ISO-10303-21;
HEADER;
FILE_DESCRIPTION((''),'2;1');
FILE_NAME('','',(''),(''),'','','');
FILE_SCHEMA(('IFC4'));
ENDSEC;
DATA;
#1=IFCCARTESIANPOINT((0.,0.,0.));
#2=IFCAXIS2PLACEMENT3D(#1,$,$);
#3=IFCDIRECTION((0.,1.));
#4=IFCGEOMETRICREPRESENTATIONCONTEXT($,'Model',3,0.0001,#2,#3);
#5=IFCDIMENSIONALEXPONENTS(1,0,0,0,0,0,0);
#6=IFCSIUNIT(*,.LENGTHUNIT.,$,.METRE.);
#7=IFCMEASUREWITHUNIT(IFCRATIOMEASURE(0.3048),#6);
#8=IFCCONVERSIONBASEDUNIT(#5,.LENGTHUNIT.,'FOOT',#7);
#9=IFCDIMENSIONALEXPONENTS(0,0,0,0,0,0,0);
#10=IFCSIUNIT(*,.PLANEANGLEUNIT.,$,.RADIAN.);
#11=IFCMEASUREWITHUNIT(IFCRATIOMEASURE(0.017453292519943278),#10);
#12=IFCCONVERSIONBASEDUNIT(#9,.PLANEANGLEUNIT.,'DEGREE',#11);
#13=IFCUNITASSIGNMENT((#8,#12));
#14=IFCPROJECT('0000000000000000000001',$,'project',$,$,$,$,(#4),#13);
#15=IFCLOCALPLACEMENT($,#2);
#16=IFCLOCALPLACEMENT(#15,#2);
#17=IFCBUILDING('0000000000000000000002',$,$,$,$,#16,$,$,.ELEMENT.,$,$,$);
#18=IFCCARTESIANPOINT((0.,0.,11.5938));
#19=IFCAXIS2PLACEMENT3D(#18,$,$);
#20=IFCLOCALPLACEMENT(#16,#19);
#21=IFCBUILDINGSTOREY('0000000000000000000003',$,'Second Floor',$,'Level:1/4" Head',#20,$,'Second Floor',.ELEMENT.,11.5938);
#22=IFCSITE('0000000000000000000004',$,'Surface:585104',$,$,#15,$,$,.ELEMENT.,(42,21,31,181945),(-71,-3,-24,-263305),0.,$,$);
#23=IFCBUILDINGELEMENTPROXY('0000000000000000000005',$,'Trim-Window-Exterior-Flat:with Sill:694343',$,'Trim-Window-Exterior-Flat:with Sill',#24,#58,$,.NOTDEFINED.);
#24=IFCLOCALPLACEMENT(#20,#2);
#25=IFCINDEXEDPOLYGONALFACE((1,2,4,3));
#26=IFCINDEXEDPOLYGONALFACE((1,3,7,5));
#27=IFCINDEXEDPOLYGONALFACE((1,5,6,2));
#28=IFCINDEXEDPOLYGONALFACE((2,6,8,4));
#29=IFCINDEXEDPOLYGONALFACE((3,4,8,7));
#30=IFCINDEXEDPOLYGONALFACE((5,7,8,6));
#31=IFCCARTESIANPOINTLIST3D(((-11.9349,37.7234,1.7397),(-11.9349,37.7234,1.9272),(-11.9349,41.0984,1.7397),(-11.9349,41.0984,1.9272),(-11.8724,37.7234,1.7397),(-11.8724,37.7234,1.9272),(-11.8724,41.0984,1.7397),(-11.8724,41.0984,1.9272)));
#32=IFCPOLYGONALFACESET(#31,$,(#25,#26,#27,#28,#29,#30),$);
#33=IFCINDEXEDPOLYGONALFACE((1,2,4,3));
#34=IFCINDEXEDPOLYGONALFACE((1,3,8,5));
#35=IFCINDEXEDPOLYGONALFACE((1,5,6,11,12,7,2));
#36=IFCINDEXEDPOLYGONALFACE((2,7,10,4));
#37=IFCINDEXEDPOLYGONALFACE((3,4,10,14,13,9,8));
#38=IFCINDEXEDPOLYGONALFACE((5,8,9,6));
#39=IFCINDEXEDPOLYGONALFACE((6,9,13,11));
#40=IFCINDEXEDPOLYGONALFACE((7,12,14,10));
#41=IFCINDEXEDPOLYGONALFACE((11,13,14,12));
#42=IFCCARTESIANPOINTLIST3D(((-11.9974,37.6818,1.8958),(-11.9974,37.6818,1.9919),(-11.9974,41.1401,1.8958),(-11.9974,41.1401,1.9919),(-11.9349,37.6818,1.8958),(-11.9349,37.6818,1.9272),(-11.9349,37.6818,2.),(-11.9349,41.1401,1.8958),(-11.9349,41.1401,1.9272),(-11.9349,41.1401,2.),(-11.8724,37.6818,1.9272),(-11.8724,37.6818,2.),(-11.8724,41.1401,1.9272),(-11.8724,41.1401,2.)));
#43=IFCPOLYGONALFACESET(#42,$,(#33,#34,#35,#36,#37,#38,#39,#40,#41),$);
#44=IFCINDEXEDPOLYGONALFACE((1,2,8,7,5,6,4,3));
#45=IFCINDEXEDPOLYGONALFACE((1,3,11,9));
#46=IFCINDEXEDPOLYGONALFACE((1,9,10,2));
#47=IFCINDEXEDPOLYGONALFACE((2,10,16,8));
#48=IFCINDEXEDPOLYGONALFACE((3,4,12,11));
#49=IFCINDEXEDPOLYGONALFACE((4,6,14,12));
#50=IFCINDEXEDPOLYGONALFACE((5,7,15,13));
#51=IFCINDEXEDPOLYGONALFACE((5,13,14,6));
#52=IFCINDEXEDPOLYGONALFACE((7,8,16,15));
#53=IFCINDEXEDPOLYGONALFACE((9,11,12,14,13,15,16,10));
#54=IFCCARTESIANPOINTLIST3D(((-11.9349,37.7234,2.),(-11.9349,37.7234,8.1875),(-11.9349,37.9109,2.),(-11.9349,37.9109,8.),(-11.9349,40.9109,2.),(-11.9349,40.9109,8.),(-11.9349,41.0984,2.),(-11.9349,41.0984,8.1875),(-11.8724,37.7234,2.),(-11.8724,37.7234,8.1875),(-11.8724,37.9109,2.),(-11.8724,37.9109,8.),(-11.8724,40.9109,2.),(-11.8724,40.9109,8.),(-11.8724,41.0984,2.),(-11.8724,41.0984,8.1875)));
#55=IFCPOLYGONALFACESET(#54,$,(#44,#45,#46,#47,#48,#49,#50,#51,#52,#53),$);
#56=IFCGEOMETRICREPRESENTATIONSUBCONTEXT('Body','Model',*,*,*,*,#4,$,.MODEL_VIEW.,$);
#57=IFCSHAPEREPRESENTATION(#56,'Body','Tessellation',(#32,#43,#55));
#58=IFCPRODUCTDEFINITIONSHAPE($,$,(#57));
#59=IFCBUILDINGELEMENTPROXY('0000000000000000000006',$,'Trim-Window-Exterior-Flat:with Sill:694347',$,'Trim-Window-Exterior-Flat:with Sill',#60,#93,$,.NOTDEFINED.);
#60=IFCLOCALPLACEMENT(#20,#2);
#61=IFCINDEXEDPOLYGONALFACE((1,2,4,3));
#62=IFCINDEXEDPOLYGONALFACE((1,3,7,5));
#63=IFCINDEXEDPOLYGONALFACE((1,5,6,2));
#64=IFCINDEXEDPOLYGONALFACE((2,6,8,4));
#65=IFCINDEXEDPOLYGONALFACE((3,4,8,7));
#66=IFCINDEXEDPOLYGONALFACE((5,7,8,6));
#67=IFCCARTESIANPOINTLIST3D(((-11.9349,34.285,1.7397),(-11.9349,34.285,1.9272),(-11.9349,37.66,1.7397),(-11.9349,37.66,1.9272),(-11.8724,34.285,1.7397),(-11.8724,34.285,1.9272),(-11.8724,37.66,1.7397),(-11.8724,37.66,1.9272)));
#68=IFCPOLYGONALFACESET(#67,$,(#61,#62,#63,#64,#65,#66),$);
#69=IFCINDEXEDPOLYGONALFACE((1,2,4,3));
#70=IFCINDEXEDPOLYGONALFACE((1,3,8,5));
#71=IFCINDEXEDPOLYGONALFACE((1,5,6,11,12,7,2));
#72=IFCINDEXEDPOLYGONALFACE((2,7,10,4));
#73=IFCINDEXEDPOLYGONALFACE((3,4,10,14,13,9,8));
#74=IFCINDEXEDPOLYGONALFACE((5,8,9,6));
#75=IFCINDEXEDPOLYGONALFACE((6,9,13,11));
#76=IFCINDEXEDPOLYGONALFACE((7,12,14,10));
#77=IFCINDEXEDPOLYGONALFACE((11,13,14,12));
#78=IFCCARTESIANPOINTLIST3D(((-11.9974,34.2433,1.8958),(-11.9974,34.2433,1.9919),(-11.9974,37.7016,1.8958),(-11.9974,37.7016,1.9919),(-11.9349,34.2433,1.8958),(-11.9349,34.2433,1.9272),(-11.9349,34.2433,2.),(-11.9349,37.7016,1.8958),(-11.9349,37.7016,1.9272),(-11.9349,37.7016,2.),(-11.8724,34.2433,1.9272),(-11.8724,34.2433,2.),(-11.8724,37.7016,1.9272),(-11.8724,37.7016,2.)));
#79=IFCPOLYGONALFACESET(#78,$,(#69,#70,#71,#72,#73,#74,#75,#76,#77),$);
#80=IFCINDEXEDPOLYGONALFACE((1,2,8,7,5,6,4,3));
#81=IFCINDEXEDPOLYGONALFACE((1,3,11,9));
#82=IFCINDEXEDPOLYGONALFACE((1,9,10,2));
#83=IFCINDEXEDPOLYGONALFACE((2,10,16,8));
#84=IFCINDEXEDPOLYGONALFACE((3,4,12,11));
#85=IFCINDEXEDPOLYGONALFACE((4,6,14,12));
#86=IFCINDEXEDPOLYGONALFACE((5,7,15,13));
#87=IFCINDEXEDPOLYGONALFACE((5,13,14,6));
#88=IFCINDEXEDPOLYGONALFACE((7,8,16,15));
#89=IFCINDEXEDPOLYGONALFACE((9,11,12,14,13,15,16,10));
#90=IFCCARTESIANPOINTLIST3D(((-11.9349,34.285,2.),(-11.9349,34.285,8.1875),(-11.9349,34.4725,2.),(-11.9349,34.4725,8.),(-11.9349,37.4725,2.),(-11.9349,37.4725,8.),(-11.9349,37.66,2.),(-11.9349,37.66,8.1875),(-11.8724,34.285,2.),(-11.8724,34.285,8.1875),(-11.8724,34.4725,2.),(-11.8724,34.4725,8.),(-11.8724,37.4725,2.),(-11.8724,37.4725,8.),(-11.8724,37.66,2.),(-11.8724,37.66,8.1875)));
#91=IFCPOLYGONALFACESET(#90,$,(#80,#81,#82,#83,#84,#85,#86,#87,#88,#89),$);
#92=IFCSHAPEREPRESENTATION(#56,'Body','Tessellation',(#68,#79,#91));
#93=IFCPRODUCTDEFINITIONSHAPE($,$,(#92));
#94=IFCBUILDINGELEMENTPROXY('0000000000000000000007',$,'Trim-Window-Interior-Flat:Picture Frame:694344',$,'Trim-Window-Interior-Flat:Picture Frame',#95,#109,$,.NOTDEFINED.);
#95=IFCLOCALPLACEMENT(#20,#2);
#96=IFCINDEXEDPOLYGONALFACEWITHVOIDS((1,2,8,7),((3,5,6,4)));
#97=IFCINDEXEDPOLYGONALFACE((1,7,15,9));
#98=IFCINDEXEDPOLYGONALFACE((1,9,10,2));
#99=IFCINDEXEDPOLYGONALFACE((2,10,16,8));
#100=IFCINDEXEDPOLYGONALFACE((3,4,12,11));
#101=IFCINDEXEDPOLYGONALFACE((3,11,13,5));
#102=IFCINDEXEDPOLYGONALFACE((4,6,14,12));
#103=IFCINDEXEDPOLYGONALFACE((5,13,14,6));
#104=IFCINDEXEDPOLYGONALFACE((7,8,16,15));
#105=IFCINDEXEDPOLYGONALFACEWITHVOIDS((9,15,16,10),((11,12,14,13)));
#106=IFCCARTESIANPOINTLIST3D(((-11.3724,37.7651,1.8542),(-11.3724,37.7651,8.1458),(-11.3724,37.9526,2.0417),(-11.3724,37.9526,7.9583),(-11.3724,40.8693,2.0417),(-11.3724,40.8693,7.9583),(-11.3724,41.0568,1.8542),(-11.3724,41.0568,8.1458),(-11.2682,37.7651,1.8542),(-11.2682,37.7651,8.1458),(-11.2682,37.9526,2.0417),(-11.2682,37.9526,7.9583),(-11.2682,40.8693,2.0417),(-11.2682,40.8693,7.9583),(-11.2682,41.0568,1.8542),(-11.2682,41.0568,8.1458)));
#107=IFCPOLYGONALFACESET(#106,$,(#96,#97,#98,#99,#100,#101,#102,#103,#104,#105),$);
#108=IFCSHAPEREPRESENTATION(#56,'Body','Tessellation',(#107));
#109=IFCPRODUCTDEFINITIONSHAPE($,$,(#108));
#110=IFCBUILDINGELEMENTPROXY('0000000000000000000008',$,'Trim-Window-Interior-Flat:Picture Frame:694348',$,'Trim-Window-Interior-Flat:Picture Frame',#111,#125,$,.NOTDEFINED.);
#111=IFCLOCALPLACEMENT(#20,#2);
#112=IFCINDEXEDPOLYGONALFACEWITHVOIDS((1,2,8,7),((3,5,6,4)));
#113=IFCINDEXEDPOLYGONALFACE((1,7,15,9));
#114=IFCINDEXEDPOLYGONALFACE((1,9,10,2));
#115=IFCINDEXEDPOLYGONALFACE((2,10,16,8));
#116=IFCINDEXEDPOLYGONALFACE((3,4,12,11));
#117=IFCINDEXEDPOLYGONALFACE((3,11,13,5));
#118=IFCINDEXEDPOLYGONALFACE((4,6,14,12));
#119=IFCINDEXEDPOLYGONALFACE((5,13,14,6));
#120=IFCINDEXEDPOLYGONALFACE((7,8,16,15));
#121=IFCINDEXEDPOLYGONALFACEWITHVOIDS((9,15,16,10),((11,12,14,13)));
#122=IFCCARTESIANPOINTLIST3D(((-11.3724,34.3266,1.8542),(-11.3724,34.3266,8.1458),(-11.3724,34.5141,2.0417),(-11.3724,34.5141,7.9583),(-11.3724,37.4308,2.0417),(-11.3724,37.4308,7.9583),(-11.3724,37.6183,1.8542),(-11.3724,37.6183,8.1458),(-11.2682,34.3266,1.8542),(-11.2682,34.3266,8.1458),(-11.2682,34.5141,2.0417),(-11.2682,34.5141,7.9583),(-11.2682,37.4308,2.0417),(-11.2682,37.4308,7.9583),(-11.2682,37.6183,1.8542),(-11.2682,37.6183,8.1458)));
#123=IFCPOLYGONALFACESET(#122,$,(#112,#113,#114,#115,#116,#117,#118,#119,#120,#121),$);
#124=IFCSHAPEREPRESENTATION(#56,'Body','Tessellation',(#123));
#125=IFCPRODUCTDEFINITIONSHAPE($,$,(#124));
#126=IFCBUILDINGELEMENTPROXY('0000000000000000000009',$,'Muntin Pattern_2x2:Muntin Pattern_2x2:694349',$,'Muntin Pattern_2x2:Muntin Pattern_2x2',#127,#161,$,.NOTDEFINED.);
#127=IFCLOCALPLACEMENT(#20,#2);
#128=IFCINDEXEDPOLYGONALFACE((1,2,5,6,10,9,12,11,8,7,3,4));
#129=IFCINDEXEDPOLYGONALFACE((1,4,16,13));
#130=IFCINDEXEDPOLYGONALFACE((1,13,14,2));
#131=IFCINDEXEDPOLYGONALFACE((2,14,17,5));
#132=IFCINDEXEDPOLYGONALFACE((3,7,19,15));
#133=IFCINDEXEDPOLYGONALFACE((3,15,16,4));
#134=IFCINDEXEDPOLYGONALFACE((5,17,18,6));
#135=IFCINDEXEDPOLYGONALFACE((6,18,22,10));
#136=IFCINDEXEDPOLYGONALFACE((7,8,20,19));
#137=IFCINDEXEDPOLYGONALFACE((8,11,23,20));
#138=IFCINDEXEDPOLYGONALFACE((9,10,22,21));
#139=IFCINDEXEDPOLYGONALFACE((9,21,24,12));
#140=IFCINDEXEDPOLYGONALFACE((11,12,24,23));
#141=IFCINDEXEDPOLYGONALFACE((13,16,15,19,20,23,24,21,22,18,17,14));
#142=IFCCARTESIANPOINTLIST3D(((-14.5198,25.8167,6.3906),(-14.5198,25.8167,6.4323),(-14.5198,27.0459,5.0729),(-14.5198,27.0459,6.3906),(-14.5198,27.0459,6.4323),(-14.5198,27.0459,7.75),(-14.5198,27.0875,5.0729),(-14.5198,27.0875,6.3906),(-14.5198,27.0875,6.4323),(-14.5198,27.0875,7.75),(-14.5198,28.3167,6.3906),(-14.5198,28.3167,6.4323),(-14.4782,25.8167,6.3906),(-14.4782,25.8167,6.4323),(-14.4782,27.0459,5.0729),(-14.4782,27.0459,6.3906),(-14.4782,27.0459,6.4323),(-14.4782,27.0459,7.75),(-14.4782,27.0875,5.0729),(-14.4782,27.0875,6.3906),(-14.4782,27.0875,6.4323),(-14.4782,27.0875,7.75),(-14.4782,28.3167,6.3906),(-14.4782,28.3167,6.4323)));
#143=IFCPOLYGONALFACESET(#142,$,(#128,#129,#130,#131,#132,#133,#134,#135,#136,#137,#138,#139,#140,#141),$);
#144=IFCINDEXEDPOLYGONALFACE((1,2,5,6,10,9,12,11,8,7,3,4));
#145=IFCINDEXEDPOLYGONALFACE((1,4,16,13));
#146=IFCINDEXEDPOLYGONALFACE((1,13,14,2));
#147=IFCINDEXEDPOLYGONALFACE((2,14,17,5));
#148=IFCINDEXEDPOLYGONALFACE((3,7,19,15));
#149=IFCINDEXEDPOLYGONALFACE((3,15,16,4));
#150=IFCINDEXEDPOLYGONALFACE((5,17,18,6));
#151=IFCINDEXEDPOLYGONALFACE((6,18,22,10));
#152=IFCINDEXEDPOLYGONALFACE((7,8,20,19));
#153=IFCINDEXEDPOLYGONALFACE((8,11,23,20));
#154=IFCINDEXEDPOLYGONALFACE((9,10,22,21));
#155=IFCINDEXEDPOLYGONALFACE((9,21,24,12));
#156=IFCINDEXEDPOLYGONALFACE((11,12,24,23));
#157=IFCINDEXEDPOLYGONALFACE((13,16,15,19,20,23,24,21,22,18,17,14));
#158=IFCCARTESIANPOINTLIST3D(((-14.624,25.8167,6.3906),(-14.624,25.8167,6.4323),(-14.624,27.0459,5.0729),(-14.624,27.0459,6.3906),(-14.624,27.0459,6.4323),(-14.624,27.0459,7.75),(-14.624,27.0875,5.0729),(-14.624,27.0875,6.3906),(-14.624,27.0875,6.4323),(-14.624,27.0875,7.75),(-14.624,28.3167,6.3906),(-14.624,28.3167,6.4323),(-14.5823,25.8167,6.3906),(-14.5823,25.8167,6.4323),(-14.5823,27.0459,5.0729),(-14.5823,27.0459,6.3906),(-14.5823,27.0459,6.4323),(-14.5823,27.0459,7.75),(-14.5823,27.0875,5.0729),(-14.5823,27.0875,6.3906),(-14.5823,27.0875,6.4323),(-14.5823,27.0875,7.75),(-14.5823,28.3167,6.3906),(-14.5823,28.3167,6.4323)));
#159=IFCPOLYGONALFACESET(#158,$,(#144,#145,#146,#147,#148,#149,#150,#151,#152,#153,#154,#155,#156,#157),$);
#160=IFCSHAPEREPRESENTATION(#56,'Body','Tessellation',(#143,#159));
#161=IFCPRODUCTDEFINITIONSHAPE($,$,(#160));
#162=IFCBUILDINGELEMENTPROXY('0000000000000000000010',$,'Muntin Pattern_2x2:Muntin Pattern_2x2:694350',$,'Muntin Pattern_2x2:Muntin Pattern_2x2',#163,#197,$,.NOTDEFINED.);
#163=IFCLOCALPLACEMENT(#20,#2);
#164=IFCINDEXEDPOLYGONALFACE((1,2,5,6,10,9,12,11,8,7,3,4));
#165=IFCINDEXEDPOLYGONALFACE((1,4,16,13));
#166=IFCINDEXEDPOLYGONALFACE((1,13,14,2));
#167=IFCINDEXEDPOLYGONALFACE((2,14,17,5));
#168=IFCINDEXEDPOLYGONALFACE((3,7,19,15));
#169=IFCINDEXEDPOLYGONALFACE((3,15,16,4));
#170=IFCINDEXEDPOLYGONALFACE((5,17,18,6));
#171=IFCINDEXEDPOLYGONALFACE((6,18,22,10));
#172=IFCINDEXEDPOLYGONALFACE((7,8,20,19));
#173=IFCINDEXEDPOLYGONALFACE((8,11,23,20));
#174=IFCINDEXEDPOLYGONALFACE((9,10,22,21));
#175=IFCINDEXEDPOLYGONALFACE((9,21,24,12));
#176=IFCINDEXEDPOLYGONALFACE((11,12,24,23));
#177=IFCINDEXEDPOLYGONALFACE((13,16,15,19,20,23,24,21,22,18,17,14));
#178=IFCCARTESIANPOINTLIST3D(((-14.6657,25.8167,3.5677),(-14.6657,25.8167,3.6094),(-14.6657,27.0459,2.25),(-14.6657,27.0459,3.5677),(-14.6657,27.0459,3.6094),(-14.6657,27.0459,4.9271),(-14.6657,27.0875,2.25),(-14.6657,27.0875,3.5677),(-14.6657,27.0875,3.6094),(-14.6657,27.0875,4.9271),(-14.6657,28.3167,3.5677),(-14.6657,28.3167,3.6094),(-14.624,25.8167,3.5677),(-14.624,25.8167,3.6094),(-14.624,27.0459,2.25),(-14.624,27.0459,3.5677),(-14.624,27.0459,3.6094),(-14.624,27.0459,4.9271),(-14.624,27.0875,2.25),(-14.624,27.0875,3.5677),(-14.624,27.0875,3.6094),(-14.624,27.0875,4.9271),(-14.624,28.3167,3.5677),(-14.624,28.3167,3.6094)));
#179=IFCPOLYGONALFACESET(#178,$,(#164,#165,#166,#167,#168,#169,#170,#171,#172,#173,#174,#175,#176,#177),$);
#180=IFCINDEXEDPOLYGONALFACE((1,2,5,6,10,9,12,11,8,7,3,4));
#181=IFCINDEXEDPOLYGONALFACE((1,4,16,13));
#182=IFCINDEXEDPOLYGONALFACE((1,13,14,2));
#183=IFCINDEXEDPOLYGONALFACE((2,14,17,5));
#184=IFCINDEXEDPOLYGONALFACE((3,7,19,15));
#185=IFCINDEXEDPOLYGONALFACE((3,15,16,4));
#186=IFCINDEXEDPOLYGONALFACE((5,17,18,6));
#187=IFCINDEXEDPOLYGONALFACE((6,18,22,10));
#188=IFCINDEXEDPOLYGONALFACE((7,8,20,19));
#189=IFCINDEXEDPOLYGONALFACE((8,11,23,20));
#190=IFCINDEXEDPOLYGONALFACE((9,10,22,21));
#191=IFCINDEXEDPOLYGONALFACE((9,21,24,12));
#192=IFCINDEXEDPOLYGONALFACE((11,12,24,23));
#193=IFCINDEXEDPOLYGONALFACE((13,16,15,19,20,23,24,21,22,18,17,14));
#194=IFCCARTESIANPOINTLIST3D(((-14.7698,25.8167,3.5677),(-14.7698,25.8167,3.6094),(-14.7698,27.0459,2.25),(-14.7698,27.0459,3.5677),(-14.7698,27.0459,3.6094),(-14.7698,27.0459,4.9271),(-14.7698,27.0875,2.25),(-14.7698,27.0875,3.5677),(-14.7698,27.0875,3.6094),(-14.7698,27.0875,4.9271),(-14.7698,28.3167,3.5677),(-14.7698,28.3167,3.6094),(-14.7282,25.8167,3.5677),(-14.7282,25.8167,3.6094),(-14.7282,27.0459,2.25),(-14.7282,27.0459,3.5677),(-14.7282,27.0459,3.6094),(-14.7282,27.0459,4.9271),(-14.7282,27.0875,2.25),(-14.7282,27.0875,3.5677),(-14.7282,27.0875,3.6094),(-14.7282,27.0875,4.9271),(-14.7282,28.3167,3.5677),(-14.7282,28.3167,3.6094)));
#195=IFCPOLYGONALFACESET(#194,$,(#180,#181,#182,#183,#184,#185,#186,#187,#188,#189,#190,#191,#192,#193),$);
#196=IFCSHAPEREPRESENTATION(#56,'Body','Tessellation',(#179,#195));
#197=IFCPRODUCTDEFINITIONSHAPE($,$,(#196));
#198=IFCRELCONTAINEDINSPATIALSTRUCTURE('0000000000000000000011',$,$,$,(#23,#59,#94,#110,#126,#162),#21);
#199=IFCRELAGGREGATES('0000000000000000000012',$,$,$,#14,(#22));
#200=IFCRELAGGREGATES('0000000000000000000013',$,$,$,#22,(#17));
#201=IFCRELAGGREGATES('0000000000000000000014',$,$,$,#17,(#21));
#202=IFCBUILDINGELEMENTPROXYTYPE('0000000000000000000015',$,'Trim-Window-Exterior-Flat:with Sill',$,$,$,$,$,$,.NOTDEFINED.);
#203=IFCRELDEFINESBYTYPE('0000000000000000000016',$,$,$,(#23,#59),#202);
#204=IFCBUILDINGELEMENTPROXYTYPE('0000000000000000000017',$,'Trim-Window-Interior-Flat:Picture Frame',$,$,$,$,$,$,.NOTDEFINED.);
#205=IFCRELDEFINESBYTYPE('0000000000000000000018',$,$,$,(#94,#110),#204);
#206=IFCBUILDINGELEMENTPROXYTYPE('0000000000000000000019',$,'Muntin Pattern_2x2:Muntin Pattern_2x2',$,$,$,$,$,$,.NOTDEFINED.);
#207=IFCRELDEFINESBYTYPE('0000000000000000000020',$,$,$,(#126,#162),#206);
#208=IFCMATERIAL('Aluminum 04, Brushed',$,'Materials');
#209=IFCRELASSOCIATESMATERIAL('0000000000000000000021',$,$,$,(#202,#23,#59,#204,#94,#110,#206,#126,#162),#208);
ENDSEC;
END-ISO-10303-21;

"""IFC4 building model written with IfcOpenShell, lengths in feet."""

from ifc_helpers import new_model, entity, si_unit, converted_unit, direction, frame, origin, place, context, subcontext, project, spatial, indexed_curve, outline, extrude, source, transform, mapped, material, type_object, type_shapes, element, save


model = new_model("IFC4")

# Units and contexts
model_context = context("Model", 3, precision=0.0001, world=origin(), true_north=direction((0.0, 1.0)))
body_context = subcontext(model_context, "Body", "Model", "MODEL_VIEW")
ifc_project = project(units=[converted_unit("LENGTHUNIT", "FOOT", entity("IfcRatioMeasure", 0.3048), si_unit("LENGTHUNIT", "METRE"), dimensions=[1, 0, 0, 0, 0, 0, 0]), converted_unit("PLANEANGLEUNIT", "DEGREE", entity("IfcRatioMeasure", 0.017453292519943278), si_unit("PLANEANGLEUNIT", "RADIAN"), dimensions=[0, 0, 0, 0, 0, 0, 0])], contexts=[model_context])

# Site, building, storey
site_placement = place(None, origin())
site = spatial("IfcSite", under=ifc_project, at=site_placement, Name="Surface:585104", CompositionType="ELEMENT", RefLatitude=(42, 21, 31, 181945), RefLongitude=(-71, -3, -24, -263305), RefElevation=0.0)
building_placement = place(site_placement, origin())
building = spatial("IfcBuilding", under=site, at=building_placement, CompositionType="ELEMENT")
storey_placement = place(building_placement, frame((0.0, 0.0, 11.5938)))
storey = spatial("IfcBuildingStorey", under=building, at=storey_placement, Name="Second Floor", ObjectType="Level:1/4\" Head", LongName="Second Floor", CompositionType="ELEMENT", Elevation=11.5938)

# Building element proxies
ifc_material_1 = material(Name="Aluminum 04, Brushed", Category="Materials")
building_element_proxy_type_1 = type_object("IfcBuildingElementProxyType", Name="Trim-Window-Exterior-Flat:with Sill", PredefinedType="NOTDEFINED", material=ifc_material_1)
shared_shape_1 = source(origin(), body_context, "Body", "SweptSolid", [
    extrude(outline(indexed_curve([(-0.0938, -1.6875), (0.0938, -1.6875), (0.0938, 1.6875), (-0.0938, 1.6875), (-0.0938, -1.6875)], self_intersect=False)), frame((0.0, 6.1665, 0.0), z_axis=(0.0, 0.0, 1.0), x_axis=(0.0, 1.0, 0.0)), (0.0, 0.0, 1.0), 0.0625),
    extrude(outline(indexed_curve([(-0.0525, -0.0625), (0.0436, -0.0625), (0.0517, 0.0), (0.0517, 0.0625), (-0.0211, 0.0625), (-0.0211, 0.0), (-0.0525, 0.0), (-0.0525, -0.0625)], self_intersect=False)), frame((-1.7292, 6.0517, 0.0625), z_axis=(1.0, 0.0, 0.0), x_axis=(0.0, -1.0, 0.0)), (0.0, 0.0, 1.0), 3.4583),
    extrude(outline(indexed_curve([(-1.6875, -3.1406), (1.6875, -3.1406), (1.6875, 3.0469), (1.5, 3.0469), (1.5, -2.9531), (-1.5, -2.9531), (-1.5, 3.0469), (-1.6875, 3.0469), (-1.6875, -3.1406)], self_intersect=False)), frame((0.0, 2.9531, 0.0)), (0.0, 0.0, 1.0), 0.0625),
])
type_shapes(building_element_proxy_type_1, [shared_shape_1])
for number, where, z_axis, x_axis, name in (
    (1, (-11.8724, 39.4109, 8.0), (-1.0, 0.0, 0.0), (0.0, 1.0, 0.0), "Trim-Window-Exterior-Flat:with Sill:694343"),
    (2, (-11.8724, 35.9725, 8.0), (-1.0, 0.0, 0.0), (0.0, 1.0, 0.0), "Trim-Window-Exterior-Flat:with Sill:694347"),
):
    element("IfcBuildingElementProxy", number, at=place(storey_placement, frame(where, z_axis=z_axis, x_axis=x_axis)), inside=storey, type_object=building_element_proxy_type_1, material=ifc_material_1, Name=name, ObjectType="Trim-Window-Exterior-Flat:with Sill", PredefinedType="NOTDEFINED", context=body_context, shape_type="MappedRepresentation", body=[
        mapped(shared_shape_1, transform((0.0, 0.0, 0.0), scale=1.0)),
    ])
building_element_proxy_type_2 = type_object("IfcBuildingElementProxyType", Name="Trim-Window-Interior-Flat:Picture Frame", PredefinedType="NOTDEFINED", material=ifc_material_1)
shared_shape_2 = source(origin(), body_context, "Body", "SweptSolid", [
    extrude(outline(indexed_curve([(-3.1458, -1.6458), (3.1458, -1.6458), (3.1458, 1.6458), (-3.1458, 1.6458), (-3.1458, -1.6458)], self_intersect=False), holes=[indexed_curve([(-2.9583, -1.4583), (-2.9583, 1.4583), (2.9583, 1.4583), (2.9583, -1.4583), (-2.9583, -1.4583)], self_intersect=False)]), frame((0.0, 3.0, 0.0), z_axis=(0.0, 0.0, 1.0), x_axis=(0.0, 1.0, 0.0)), (0.0, 0.0, 1.0), 0.1042),
])
type_shapes(building_element_proxy_type_2, [shared_shape_2])
for number, where, z_axis, x_axis, name in (
    (3, (-11.3724, 39.4109, 8.0), (1.0, 0.0, 0.0), (0.0, -1.0, 0.0), "Trim-Window-Interior-Flat:Picture Frame:694344"),
    (4, (-11.3724, 35.9725, 8.0), (1.0, 0.0, 0.0), (0.0, -1.0, 0.0), "Trim-Window-Interior-Flat:Picture Frame:694348"),
):
    element("IfcBuildingElementProxy", number, at=place(storey_placement, frame(where, z_axis=z_axis, x_axis=x_axis)), inside=storey, type_object=building_element_proxy_type_2, material=ifc_material_1, Name=name, ObjectType="Trim-Window-Interior-Flat:Picture Frame", PredefinedType="NOTDEFINED", context=body_context, shape_type="MappedRepresentation", body=[
        mapped(shared_shape_2, transform((0.0, 0.0, 0.0), scale=1.0)),
    ])
building_element_proxy_type_3 = type_object("IfcBuildingElementProxyType", Name="Muntin Pattern_2x2:Muntin Pattern_2x2", PredefinedType="NOTDEFINED", material=ifc_material_1)
shared_shape_3 = source(origin(), body_context, "Body", "SweptSolid", [
    extrude(outline(indexed_curve([(0.0208, -0.0208), (1.3385, -0.0208), (1.3385, 0.0208), (0.0208, 0.0208), (0.0208, 1.25), (-0.0208, 1.25), (-0.0208, 0.0208), (-1.3385, 0.0208), (-1.3385, -0.0208), (-0.0208, -0.0208), (-0.0208, -1.25), (0.0208, -1.25), (0.0208, -0.0208)], self_intersect=False)), frame((0.0, 0.0312, 1.3385), z_axis=(0.0, 1.0, 0.0), x_axis=(0.0, 0.0, 1.0)), (0.0, 0.0, 1.0), 0.0417),
    extrude(outline(indexed_curve([(0.0208, -0.0208), (1.3385, -0.0208), (1.3385, 0.0208), (0.0208, 0.0208), (0.0208, 1.25), (-0.0208, 1.25), (-0.0208, 0.0208), (-1.3385, 0.0208), (-1.3385, -0.0208), (-0.0208, -0.0208), (-0.0208, -1.25), (0.0208, -1.25), (0.0208, -0.0208)], self_intersect=False)), frame((0.0, -0.0729, 1.3385), z_axis=(0.0, 1.0, 0.0), x_axis=(0.0, 0.0, 1.0)), (0.0, 0.0, 1.0), 0.0417),
])
type_shapes(building_element_proxy_type_3, [shared_shape_3])
for number, where, z_axis, x_axis, name in (
    (5, (-14.5511, 27.0667, 5.0729), (0.0, 0.0, 1.0), (0.0, -1.0, 0.0), "Muntin Pattern_2x2:Muntin Pattern_2x2:694349"),
    (6, (-14.6969, 27.0667, 2.25), (0.0, 0.0, 1.0), (0.0, -1.0, 0.0), "Muntin Pattern_2x2:Muntin Pattern_2x2:694350"),
):
    element("IfcBuildingElementProxy", number, at=place(storey_placement, frame(where, z_axis=z_axis, x_axis=x_axis)), inside=storey, type_object=building_element_proxy_type_3, material=ifc_material_1, Name=name, ObjectType="Muntin Pattern_2x2:Muntin Pattern_2x2", PredefinedType="NOTDEFINED", context=body_context, shape_type="MappedRepresentation", body=[
        mapped(shared_shape_3, transform((0.0, 0.0, 0.0), scale=1.0)),
    ])

save(model, "model.ifc")
